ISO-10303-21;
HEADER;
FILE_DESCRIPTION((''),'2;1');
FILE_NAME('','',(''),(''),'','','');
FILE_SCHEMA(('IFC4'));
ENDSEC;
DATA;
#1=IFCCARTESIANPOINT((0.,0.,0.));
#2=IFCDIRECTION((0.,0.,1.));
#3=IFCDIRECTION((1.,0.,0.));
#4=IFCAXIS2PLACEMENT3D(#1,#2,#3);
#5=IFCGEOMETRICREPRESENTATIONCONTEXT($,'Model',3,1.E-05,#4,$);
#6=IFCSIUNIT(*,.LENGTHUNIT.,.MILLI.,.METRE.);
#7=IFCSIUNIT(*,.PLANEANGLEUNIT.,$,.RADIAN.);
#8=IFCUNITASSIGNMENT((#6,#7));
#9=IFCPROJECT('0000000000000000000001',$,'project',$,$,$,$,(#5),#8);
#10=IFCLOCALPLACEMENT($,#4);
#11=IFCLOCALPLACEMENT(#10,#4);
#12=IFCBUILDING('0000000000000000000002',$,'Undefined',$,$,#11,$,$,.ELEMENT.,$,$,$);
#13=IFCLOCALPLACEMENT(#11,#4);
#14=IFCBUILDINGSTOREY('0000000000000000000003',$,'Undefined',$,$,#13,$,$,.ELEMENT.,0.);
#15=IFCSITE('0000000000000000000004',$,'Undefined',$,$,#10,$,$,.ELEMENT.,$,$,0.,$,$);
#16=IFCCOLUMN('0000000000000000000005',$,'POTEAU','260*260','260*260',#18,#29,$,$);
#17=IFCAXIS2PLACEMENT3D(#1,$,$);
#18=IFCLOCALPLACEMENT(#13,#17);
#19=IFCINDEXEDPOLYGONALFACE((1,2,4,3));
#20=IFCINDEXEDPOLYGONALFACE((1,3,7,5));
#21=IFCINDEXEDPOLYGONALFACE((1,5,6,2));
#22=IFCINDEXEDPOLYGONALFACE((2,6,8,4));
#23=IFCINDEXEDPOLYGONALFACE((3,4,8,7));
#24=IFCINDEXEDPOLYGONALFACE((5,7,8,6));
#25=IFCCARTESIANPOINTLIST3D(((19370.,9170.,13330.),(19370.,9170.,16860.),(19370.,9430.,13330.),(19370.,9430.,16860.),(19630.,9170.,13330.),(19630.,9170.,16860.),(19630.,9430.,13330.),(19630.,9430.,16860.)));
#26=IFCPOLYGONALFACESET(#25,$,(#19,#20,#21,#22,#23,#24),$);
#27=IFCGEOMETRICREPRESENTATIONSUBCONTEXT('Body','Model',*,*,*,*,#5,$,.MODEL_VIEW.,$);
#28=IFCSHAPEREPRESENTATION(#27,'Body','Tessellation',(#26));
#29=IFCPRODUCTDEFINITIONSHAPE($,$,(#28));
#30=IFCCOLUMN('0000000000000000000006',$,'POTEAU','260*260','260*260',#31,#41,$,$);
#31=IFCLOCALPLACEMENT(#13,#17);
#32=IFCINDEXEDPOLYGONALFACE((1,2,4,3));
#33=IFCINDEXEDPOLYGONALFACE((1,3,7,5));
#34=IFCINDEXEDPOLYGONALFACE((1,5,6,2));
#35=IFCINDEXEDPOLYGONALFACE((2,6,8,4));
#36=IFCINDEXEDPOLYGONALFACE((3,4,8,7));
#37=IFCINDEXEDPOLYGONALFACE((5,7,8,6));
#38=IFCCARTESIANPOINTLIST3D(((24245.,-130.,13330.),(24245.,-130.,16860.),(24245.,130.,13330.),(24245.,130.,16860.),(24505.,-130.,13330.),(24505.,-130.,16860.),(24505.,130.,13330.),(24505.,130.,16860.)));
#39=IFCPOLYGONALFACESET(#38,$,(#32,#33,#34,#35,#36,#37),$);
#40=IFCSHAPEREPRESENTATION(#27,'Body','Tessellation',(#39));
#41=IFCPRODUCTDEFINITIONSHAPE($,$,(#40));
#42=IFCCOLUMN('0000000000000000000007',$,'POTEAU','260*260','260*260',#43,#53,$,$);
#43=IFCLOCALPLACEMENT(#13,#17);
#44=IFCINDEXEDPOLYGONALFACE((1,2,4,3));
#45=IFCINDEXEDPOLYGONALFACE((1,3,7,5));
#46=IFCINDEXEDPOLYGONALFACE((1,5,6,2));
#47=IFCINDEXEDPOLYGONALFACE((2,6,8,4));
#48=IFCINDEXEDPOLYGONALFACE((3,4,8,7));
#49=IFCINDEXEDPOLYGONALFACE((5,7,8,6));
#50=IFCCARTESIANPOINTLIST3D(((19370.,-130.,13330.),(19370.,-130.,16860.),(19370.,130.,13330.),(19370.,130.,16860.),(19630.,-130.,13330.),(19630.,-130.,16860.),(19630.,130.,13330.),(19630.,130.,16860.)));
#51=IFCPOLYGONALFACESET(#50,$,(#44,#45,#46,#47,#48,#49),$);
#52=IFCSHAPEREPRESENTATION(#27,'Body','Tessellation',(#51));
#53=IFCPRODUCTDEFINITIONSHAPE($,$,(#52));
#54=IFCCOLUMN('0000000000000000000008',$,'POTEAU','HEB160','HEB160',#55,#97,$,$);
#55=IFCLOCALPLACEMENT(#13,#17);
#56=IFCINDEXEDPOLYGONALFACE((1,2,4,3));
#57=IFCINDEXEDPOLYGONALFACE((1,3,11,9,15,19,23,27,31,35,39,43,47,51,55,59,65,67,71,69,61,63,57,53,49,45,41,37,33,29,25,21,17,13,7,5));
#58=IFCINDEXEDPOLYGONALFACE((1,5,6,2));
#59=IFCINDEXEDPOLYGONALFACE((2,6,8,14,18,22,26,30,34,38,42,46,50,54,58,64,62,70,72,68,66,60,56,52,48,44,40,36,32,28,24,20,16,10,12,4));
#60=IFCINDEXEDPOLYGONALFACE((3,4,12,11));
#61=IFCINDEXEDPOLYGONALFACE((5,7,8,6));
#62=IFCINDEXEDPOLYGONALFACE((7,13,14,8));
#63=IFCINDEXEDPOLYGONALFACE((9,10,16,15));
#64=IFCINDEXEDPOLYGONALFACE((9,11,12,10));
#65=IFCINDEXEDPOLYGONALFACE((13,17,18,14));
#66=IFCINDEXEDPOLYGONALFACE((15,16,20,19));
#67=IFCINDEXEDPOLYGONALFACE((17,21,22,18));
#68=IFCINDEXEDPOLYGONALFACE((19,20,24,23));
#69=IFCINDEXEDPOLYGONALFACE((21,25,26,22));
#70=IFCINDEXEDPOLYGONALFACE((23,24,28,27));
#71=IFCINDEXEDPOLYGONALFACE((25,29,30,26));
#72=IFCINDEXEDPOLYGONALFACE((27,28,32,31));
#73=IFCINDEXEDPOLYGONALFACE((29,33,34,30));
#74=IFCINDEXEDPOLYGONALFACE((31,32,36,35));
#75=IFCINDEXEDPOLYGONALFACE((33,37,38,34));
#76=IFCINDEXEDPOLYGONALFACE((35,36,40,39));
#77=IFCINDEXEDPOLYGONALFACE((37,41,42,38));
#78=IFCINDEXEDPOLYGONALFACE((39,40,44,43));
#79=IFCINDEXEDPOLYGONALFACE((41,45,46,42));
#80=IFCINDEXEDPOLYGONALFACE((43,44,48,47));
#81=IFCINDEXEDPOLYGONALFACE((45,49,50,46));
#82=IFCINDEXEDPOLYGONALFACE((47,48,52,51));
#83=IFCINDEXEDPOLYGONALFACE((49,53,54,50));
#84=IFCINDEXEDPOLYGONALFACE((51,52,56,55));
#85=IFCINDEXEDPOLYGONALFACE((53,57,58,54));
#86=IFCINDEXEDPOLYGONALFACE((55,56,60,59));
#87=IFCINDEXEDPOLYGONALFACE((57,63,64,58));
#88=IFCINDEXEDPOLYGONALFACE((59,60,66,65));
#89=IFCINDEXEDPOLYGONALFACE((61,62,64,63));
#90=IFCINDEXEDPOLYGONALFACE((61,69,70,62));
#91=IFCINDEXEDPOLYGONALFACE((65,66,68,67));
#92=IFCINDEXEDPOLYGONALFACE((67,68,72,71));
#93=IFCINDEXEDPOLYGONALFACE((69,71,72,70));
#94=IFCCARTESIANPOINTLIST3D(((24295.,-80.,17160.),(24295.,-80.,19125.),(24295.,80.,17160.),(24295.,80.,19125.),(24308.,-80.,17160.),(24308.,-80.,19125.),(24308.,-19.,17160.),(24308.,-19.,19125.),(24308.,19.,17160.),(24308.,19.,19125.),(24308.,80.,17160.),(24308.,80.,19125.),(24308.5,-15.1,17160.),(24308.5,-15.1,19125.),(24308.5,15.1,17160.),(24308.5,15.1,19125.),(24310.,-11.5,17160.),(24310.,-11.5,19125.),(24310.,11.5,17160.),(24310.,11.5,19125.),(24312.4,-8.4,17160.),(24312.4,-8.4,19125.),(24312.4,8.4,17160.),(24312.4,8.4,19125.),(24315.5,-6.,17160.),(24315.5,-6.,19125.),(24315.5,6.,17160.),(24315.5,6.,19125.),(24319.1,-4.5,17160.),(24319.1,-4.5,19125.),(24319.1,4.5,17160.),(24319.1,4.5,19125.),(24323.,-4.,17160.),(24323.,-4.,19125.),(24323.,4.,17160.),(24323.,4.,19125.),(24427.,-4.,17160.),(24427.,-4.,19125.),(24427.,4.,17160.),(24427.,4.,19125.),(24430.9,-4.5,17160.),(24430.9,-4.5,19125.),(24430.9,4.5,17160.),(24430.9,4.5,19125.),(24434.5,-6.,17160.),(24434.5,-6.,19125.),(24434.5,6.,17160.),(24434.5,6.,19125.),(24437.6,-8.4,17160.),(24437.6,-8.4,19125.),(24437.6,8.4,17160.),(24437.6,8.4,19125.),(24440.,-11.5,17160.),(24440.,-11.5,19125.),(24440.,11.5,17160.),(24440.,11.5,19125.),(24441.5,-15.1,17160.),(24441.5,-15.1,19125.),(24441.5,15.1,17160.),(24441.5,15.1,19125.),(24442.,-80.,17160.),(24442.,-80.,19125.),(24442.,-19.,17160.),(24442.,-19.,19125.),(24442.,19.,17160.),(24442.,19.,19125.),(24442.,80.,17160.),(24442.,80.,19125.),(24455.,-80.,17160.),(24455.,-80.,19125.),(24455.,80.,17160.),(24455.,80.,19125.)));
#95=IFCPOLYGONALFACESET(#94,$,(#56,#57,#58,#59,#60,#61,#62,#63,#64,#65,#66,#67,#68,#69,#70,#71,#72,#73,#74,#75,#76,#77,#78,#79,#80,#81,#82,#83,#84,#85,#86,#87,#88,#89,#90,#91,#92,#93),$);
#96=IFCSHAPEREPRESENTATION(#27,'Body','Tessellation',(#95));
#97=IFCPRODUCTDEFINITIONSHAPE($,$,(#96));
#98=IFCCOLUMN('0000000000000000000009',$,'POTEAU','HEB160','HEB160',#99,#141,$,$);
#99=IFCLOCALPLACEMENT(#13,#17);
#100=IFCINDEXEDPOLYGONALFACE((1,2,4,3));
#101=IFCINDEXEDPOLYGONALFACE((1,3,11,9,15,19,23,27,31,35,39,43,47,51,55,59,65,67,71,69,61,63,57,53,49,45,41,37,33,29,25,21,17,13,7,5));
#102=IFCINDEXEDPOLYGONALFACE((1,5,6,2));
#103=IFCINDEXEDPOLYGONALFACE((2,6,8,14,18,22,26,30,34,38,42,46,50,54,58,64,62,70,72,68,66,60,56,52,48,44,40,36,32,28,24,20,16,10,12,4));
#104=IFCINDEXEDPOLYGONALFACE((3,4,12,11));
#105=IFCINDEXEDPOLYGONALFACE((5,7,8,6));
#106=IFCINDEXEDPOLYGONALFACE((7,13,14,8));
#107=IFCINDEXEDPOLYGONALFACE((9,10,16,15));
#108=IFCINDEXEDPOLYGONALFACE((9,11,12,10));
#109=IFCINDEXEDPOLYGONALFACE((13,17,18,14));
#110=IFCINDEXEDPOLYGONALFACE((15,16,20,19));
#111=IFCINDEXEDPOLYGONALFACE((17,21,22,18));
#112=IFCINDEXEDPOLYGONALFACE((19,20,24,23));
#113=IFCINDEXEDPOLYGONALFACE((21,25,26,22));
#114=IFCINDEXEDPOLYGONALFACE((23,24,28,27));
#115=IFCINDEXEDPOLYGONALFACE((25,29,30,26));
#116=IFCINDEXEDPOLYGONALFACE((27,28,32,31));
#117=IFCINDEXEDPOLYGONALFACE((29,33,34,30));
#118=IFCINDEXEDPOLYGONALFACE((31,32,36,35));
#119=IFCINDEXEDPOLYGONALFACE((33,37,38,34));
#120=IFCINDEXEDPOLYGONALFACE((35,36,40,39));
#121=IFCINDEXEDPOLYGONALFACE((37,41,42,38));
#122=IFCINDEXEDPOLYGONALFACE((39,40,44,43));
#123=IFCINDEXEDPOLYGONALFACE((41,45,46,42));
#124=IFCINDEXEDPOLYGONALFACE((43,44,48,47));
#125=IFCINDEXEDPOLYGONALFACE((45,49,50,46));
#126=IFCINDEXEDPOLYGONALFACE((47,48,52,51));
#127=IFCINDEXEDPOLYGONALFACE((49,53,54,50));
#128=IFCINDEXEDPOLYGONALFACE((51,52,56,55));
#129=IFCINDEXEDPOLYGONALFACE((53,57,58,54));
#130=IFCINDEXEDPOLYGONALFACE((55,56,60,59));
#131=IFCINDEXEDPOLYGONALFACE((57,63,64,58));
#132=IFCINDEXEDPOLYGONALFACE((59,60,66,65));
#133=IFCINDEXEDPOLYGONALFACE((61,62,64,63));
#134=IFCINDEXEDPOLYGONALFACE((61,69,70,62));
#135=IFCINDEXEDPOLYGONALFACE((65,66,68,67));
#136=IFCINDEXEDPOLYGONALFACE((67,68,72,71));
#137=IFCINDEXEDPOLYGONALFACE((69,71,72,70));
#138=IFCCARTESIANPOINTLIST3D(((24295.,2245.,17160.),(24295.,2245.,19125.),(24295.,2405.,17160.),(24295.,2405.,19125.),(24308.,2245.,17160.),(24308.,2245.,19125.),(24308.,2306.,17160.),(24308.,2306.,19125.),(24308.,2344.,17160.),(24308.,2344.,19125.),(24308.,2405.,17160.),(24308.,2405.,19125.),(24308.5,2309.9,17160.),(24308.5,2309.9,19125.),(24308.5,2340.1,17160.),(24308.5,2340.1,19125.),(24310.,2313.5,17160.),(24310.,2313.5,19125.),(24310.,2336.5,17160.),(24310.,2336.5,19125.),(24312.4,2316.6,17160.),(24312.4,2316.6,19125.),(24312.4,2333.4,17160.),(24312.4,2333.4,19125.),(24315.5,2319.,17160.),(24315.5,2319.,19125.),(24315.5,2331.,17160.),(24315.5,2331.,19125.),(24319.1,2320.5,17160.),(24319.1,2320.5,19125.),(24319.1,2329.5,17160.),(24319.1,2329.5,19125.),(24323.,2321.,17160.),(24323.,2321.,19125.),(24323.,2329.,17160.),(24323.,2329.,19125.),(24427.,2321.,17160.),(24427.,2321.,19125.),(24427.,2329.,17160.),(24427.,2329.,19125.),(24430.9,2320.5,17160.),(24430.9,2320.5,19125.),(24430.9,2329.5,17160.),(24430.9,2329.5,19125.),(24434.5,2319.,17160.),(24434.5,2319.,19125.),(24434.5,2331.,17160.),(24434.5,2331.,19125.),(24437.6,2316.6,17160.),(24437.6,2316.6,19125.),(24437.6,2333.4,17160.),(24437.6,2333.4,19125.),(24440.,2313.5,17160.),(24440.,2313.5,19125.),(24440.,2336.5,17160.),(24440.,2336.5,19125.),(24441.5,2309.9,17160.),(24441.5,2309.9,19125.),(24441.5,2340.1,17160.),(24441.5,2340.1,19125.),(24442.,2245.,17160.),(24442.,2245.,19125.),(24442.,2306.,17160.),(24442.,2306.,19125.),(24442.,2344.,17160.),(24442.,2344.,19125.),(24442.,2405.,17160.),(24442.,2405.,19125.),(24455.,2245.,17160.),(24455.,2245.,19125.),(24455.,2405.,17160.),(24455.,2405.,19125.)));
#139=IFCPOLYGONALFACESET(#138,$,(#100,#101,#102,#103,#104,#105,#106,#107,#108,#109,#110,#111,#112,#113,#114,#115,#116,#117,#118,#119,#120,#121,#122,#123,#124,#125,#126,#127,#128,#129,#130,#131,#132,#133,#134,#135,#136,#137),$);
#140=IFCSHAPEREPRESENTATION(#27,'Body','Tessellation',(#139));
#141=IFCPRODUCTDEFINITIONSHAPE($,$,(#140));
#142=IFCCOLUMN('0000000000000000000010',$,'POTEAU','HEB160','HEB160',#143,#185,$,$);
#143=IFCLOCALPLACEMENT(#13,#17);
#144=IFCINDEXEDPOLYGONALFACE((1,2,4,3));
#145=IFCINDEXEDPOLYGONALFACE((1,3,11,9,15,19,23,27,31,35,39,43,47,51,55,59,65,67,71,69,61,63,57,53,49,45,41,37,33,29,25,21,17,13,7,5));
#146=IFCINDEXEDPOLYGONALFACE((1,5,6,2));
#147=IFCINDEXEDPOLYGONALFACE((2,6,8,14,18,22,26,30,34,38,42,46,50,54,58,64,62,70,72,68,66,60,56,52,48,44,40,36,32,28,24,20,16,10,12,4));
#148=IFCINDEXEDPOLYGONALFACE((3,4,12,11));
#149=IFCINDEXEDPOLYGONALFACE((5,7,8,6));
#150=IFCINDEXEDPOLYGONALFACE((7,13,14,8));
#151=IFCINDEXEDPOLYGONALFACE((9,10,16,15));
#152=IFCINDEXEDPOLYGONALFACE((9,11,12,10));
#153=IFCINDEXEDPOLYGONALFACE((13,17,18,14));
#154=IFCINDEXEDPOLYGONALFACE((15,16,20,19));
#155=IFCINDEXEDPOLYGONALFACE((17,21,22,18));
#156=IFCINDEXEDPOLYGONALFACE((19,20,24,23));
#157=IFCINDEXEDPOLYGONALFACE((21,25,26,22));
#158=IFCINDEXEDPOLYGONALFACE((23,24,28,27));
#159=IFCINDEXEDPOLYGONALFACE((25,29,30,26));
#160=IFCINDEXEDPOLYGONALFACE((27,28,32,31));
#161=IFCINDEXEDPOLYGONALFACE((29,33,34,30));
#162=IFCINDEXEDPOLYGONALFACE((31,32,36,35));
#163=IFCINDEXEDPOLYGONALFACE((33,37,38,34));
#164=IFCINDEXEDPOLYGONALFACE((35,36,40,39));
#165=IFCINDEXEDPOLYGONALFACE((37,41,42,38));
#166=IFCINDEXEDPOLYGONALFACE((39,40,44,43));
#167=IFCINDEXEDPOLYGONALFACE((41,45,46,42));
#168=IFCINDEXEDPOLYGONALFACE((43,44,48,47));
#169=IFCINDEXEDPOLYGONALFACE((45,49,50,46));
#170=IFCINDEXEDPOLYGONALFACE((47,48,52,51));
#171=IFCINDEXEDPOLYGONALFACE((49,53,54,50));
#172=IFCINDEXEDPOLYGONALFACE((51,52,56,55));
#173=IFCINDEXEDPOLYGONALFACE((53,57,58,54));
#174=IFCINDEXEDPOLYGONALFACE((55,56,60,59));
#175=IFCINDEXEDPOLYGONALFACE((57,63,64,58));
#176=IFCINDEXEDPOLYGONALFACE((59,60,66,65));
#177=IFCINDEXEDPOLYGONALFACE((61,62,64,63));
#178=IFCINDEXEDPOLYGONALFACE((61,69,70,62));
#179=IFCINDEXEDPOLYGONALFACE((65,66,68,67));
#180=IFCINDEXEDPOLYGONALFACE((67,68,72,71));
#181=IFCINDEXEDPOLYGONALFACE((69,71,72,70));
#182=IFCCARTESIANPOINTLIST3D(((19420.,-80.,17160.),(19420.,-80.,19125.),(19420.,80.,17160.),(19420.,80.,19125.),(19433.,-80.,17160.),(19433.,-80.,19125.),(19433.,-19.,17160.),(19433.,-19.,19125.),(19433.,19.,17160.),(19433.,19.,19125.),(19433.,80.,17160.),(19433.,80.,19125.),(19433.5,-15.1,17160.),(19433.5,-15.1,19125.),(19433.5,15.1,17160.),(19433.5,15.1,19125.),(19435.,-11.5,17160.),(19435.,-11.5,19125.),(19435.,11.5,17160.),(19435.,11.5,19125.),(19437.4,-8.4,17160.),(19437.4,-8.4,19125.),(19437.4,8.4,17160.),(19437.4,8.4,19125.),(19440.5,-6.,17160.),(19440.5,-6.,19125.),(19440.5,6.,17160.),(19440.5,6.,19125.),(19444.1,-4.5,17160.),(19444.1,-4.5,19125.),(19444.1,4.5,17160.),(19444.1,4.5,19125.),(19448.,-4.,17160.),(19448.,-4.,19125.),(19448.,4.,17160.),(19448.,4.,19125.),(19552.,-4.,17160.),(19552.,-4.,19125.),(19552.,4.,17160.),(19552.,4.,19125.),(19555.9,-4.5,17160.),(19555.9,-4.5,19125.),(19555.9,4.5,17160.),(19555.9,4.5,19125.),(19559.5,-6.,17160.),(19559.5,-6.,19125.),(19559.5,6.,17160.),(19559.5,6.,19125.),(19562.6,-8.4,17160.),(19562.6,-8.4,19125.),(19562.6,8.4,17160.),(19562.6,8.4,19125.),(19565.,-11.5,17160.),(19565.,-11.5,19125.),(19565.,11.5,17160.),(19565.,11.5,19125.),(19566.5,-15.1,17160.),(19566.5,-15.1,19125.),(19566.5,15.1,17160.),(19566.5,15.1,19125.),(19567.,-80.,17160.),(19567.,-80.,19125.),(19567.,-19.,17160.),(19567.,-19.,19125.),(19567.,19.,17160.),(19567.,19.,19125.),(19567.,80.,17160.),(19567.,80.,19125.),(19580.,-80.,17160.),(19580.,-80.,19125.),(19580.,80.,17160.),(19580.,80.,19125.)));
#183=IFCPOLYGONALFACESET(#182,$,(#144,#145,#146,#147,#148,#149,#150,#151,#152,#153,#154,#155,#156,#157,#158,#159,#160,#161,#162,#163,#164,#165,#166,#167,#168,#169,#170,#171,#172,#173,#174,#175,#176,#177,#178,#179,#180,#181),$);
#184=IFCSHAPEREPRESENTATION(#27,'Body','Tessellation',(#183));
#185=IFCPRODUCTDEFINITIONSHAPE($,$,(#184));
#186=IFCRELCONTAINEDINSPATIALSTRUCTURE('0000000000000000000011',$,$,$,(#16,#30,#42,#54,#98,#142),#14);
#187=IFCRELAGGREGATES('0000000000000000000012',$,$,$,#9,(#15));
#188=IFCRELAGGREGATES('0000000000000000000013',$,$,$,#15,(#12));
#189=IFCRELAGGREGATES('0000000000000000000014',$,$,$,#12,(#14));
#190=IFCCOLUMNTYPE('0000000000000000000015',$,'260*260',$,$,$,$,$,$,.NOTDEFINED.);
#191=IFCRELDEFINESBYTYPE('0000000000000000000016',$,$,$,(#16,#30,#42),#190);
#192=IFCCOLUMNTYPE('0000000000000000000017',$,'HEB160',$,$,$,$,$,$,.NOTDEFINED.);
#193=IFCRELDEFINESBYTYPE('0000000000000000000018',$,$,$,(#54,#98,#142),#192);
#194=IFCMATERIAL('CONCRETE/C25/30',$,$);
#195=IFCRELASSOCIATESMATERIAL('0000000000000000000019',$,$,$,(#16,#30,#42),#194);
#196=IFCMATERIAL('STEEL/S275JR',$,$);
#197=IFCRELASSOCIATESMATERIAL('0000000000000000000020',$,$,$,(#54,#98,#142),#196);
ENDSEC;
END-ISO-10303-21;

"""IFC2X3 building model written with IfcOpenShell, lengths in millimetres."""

from ifc_helpers import new_model, si_unit, frame, origin_with_axes, origin_2d_with_axis, place, context, subcontext, project, spatial, rectangle, i_section, extrude, material, type_object, element, save


model = new_model("IFC2X3")

# Units and contexts
model_context = context("Model", 3, precision=1e-05, world=origin_with_axes())
body_context = subcontext(model_context, "Body", "Model", "MODEL_VIEW")
ifc_project = project(units=[si_unit("LENGTHUNIT", "METRE", prefix="MILLI"), si_unit("PLANEANGLEUNIT", "RADIAN")], contexts=[model_context])

# Site, building, storey
site_placement = place(None, origin_with_axes())
site = spatial("IfcSite", under=ifc_project, at=site_placement, Name="Undefined", CompositionType="ELEMENT", RefElevation=0.0)
building_placement = place(site_placement, origin_with_axes())
building = spatial("IfcBuilding", under=site, at=building_placement, Name="Undefined", CompositionType="ELEMENT")
storey_placement = place(building_placement, origin_with_axes())
storey = spatial("IfcBuildingStorey", under=building, at=storey_placement, Name="Undefined", CompositionType="ELEMENT", Elevation=0.0)

# Columns
ifc_material_1 = material(Name="CONCRETE/C25/30")
column_type_1 = type_object("IfcColumnType", Name="260*260", PredefinedType="NOTDEFINED")
for number, where, z_axis, x_axis, name in (
    (1, (19500.0, 9300.0, 13330.0), (0.0, 0.0, 1.0), (1.0, 0.0, 0.0), "POTEAU"),
    (2, (24375.0, 0.0, 13330.0), (0.0, 0.0, 1.0), (1.0, 0.0, 0.0), "POTEAU"),
    (3, (19500.0, 0.0, 13330.0), (0.0, 0.0, 1.0), (1.0, 0.0, 0.0), "POTEAU"),
):
    element("IfcColumn", number, at=place(storey_placement, frame(where, z_axis=z_axis, x_axis=x_axis)), inside=storey, type_object=column_type_1, material=ifc_material_1, Name=name, Description="260*260", ObjectType="260*260", context=body_context, shape_type="SweptSolid", body=[
        extrude(rectangle(XDim=260.0, YDim=260.0, at=origin_2d_with_axis()), frame((0.0, 0.0, 3530.0), z_axis=(0.0, 0.0, -1.0), x_axis=(-1.0, 0.0, 0.0)), (0.0, 0.0, 1.0), 3530.0),
    ])
ifc_material_2 = material(Name="STEEL/S275JR")
column_type_2 = type_object("IfcColumnType", Name="HEB160", PredefinedType="NOTDEFINED")
for number, where, z_axis, x_axis, name in (
    (4, (24375.0, 0.0, 17160.0), (0.0, 0.0, 1.0), (1.0, 0.0, 0.0), "POTEAU"),
    (5, (24375.0, 2325.0, 17160.0), (0.0, 0.0, 1.0), (1.0, 0.0, 0.0), "POTEAU"),
    (6, (19500.0, 0.0, 17160.0), (0.0, 0.0, 1.0), (1.0, 0.0, 0.0), "POTEAU"),
):
    element("IfcColumn", number, at=place(storey_placement, frame(where, z_axis=z_axis, x_axis=x_axis)), inside=storey, type_object=column_type_2, material=ifc_material_2, Name=name, Description="HEB160", ObjectType="HEB160", context=body_context, shape_type="SweptSolid", body=[
        extrude(i_section(OverallWidth=160.0, OverallDepth=160.0, WebThickness=8.0, FlangeThickness=13.0, FilletRadius=15.0, at=origin_2d_with_axis()), frame((0.0, 0.0, 1965.0), z_axis=(0.0, 0.0, -1.0), x_axis=(0.0, -1.0, 0.0)), (0.0, 0.0, 1.0), 1965.0),
    ])

save(model, "model.ifc")
